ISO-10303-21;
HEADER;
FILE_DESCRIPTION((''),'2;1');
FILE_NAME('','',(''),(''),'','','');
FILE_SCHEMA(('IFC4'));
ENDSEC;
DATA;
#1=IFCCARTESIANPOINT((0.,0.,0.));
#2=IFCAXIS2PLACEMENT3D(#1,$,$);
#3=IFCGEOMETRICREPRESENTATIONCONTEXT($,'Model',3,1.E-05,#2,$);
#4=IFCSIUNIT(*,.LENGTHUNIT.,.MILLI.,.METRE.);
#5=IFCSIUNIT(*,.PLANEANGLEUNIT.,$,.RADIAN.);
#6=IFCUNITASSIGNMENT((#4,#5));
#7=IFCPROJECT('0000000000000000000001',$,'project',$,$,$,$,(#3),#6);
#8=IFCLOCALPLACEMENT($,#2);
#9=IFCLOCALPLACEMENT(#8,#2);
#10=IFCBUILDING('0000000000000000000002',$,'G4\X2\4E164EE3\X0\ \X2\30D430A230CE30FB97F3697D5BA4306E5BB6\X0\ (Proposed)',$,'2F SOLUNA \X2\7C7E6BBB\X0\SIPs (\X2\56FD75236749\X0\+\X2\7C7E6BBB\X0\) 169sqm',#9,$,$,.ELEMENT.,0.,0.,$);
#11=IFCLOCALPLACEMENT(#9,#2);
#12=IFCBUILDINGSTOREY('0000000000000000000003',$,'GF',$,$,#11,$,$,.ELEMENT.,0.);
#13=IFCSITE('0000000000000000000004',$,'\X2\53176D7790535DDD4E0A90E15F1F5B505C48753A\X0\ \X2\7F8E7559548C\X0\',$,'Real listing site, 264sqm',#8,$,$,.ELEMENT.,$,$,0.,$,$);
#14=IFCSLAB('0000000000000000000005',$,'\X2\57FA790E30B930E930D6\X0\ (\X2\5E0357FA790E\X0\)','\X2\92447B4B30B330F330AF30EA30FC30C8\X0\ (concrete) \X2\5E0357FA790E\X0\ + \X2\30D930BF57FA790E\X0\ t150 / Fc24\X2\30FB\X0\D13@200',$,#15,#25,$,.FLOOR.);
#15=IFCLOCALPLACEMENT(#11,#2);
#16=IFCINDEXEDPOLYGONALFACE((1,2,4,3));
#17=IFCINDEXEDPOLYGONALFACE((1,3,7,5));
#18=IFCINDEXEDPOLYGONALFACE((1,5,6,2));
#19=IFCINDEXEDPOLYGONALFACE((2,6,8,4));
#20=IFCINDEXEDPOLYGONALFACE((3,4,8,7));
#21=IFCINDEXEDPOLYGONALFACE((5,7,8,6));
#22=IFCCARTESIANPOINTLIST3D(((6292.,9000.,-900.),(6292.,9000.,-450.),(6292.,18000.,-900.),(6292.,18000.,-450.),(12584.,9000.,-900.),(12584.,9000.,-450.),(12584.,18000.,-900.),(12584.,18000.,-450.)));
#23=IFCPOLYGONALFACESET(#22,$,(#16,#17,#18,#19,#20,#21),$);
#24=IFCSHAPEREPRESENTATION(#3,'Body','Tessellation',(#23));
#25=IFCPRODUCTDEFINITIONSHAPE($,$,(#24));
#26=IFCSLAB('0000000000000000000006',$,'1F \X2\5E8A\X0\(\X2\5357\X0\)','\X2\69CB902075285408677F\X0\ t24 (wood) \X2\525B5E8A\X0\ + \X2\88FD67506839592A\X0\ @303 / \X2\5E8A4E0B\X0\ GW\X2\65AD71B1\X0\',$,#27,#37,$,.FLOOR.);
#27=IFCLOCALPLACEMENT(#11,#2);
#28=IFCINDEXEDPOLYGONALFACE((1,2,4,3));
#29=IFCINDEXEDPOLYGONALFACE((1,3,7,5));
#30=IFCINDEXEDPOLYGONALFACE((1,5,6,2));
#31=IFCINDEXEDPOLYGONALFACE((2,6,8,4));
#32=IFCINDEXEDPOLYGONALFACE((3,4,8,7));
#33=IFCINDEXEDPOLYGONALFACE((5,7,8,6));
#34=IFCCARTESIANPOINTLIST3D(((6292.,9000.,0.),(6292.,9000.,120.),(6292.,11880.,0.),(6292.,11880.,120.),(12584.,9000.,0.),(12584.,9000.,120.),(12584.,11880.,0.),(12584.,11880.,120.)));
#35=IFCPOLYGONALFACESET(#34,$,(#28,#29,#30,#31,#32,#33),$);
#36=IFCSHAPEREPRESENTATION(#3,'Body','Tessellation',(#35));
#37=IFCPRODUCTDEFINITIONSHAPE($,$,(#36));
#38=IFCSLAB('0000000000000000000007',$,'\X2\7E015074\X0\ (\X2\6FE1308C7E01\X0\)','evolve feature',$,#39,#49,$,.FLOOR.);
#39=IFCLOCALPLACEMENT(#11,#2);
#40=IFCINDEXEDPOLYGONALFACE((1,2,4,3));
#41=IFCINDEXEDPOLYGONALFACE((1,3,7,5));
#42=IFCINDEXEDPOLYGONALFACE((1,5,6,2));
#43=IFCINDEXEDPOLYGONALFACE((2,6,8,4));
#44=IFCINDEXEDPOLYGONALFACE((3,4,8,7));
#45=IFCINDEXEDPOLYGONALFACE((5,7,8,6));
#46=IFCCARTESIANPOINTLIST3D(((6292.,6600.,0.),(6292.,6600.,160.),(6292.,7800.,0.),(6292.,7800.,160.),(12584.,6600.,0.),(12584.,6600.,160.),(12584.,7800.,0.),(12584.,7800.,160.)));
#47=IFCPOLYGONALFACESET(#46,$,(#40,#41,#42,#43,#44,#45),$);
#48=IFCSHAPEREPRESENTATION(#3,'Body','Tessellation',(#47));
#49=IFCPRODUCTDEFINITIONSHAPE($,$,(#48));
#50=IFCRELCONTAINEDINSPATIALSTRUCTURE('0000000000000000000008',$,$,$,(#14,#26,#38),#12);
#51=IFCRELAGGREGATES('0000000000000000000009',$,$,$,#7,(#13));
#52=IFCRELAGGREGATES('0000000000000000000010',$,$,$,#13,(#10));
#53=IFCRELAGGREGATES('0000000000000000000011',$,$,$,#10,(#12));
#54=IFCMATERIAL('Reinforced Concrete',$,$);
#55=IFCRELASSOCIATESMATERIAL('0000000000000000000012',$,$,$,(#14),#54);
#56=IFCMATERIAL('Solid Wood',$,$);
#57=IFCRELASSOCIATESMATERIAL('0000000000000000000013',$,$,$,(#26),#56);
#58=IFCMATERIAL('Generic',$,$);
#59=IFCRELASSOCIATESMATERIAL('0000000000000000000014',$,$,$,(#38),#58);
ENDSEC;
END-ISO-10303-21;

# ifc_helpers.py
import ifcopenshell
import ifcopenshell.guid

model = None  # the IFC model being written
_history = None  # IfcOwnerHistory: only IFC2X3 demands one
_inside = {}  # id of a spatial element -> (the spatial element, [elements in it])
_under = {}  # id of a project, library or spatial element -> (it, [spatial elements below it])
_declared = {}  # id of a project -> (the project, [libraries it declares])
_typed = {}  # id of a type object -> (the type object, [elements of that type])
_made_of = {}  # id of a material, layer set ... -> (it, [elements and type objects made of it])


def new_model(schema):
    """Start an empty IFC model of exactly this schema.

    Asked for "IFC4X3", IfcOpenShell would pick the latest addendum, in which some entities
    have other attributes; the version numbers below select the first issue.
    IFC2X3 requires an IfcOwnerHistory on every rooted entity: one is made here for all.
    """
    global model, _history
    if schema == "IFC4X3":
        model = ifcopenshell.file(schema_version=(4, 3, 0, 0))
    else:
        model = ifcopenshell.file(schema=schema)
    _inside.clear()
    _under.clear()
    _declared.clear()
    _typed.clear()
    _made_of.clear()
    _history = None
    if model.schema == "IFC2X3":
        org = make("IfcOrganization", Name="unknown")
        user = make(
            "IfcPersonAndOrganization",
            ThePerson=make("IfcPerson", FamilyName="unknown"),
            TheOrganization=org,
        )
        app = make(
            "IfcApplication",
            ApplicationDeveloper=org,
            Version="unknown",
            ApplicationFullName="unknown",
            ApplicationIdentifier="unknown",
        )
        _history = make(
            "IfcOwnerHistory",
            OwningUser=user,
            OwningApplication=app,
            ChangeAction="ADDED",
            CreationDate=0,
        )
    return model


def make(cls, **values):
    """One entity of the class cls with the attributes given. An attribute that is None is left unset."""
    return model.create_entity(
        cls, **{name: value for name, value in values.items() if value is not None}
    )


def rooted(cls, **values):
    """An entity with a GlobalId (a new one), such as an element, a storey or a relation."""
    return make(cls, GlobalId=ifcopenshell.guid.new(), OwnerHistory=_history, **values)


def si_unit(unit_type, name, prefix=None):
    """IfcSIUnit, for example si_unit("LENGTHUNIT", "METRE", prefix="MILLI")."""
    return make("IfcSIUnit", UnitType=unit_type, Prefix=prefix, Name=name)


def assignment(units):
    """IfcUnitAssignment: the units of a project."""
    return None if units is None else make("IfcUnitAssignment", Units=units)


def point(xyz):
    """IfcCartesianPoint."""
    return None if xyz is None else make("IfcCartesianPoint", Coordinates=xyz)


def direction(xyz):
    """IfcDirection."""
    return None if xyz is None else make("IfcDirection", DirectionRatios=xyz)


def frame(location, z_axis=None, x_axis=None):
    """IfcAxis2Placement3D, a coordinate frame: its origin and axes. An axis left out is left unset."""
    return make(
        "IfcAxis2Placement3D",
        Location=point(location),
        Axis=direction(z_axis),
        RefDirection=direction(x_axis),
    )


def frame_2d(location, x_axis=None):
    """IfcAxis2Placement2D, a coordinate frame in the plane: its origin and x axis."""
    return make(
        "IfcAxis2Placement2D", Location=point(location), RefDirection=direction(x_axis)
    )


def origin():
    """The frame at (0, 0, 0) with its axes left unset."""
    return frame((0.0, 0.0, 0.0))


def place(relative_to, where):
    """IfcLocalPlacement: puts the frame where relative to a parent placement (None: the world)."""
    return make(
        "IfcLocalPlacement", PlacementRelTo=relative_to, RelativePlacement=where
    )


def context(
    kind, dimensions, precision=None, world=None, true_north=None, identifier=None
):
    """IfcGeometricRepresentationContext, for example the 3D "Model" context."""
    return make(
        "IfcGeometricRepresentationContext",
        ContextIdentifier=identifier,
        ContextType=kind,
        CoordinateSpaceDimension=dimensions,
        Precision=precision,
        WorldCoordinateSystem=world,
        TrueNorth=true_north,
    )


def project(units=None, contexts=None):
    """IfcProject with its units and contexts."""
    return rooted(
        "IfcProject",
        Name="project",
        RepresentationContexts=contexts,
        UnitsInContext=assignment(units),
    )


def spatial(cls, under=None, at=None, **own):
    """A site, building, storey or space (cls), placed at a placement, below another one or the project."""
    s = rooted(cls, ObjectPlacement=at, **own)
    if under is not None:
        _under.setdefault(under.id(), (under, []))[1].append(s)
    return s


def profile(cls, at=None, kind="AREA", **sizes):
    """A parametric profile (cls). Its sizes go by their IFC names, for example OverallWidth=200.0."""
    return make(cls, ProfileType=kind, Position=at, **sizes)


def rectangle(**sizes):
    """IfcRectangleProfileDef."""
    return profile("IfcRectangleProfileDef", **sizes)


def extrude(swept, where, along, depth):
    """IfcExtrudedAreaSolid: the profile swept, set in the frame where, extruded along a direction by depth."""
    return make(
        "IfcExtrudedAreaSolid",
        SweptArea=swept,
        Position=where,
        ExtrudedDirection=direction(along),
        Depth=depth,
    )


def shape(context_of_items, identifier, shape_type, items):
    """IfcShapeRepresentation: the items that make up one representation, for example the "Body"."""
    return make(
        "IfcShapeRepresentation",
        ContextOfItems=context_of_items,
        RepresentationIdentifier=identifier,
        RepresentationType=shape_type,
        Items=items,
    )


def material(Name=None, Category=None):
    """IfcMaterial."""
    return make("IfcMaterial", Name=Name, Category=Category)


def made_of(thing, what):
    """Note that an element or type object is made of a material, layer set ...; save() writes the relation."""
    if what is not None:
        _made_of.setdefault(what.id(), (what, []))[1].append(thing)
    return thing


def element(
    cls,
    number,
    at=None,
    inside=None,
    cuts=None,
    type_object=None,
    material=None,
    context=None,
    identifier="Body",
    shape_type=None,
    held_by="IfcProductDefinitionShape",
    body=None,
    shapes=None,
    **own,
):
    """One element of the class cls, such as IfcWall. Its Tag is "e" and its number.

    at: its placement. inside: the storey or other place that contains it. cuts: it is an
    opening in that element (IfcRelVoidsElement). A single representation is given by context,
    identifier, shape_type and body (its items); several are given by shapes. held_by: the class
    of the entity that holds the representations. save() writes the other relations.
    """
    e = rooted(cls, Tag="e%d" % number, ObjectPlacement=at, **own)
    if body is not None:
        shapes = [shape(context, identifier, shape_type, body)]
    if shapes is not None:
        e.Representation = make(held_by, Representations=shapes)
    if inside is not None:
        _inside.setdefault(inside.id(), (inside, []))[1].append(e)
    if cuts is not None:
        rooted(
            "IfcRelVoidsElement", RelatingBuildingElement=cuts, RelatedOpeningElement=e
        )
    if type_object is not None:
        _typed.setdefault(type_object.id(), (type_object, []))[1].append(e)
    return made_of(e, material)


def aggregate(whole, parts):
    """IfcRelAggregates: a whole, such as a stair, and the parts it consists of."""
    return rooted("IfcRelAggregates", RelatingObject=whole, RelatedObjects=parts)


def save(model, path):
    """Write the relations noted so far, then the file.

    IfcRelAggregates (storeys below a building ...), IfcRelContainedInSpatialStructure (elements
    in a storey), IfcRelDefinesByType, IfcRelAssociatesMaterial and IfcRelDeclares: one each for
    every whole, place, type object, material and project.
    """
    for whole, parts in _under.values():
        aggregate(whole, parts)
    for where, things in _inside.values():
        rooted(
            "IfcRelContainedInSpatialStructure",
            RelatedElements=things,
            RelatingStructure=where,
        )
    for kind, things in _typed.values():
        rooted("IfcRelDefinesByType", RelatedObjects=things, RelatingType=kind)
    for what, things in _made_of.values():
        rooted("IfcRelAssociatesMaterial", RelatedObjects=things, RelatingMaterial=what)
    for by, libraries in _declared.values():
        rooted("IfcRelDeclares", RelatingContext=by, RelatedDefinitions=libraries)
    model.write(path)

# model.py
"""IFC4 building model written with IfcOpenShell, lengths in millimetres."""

from ifc_helpers import new_model, si_unit, frame, frame_2d, origin, place, context, project, spatial, rectangle, extrude, material, element, save


model = new_model("IFC4")

# Units and contexts
model_context = context("Model", 3, precision=1e-05, world=origin())
ifc_project = project(units=[si_unit("LENGTHUNIT", "METRE", prefix="MILLI"), si_unit("PLANEANGLEUNIT", "RADIAN")], contexts=[model_context])

# Site, building, storey
site_placement = place(None, origin())
site = spatial("IfcSite", under=ifc_project, at=site_placement, Name="北海道川上郡弟子屈町 美留和", ObjectType="Real listing site, 264sqm", CompositionType="ELEMENT", RefElevation=0.0)
building_placement = place(site_placement, origin())
building = spatial("IfcBuilding", under=site, at=building_placement, Name="G4世代 ピアノ・音楽室の家 (Proposed)", ObjectType="2F SOLUNA 籾殻SIPs (国産杉+籾殻) 169sqm", CompositionType="ELEMENT", ElevationOfRefHeight=0.0, ElevationOfTerrain=0.0)
storey_placement = place(building_placement, origin())
storey = spatial("IfcBuildingStorey", under=building, at=storey_placement, Name="GF", CompositionType="ELEMENT", Elevation=0.0)

# Slabs
ifc_material_1 = material(Name="Reinforced Concrete")
slab_1_placement = place(storey_placement, frame((3146.0, 4500.0, -450.0)))
element("IfcSlab", 1, at=slab_1_placement, inside=storey, material=ifc_material_1, Name="基礎スラブ (布基礎)", Description="鉄筋コンクリート (concrete) 布基礎 + ベタ基礎 t150 / Fc24・D13@200", PredefinedType="FLOOR", context=model_context, shape_type="SweptSolid", body=[
    extrude(rectangle(XDim=6292.0, YDim=9000.0, at=frame_2d((3146.0, 4500.0))), frame((3146.0, 4500.0, -450.0)), (0.0, 0.0, 1.0), 450.0),
])
ifc_material_2 = material(Name="Solid Wood")
slab_2_placement = place(storey_placement, frame((3146.0, 4500.0, 0.0)))
element("IfcSlab", 2, at=slab_2_placement, inside=storey, material=ifc_material_2, Name="1F 床(南)", Description="構造用合板 t24 (wood) 剛床 + 製材根太 @303 / 床下 GW断熱", PredefinedType="FLOOR", context=model_context, shape_type="SweptSolid", body=[
    extrude(rectangle(XDim=6292.0, YDim=2880.0, at=frame_2d((3146.0, 1440.0))), frame((3146.0, 4500.0, 0.0)), (0.0, 0.0, 1.0), 120.0),
])
ifc_material_3 = material(Name="Generic")
slab_3_placement = place(storey_placement, frame((3146.0, 3300.0, 0.0)))
element("IfcSlab", 3, at=slab_3_placement, inside=storey, material=ifc_material_3, Name="縁側 (濡れ縁)", Description="evolve feature", PredefinedType="FLOOR", context=model_context, shape_type="SweptSolid", body=[
    extrude(rectangle(XDim=6292.0, YDim=1200.0, at=frame_2d((3146.0, 600.0))), frame((3146.0, 3300.0, 0.0)), (0.0, 0.0, 1.0), 160.0),
])

save(model, "model.ifc")
